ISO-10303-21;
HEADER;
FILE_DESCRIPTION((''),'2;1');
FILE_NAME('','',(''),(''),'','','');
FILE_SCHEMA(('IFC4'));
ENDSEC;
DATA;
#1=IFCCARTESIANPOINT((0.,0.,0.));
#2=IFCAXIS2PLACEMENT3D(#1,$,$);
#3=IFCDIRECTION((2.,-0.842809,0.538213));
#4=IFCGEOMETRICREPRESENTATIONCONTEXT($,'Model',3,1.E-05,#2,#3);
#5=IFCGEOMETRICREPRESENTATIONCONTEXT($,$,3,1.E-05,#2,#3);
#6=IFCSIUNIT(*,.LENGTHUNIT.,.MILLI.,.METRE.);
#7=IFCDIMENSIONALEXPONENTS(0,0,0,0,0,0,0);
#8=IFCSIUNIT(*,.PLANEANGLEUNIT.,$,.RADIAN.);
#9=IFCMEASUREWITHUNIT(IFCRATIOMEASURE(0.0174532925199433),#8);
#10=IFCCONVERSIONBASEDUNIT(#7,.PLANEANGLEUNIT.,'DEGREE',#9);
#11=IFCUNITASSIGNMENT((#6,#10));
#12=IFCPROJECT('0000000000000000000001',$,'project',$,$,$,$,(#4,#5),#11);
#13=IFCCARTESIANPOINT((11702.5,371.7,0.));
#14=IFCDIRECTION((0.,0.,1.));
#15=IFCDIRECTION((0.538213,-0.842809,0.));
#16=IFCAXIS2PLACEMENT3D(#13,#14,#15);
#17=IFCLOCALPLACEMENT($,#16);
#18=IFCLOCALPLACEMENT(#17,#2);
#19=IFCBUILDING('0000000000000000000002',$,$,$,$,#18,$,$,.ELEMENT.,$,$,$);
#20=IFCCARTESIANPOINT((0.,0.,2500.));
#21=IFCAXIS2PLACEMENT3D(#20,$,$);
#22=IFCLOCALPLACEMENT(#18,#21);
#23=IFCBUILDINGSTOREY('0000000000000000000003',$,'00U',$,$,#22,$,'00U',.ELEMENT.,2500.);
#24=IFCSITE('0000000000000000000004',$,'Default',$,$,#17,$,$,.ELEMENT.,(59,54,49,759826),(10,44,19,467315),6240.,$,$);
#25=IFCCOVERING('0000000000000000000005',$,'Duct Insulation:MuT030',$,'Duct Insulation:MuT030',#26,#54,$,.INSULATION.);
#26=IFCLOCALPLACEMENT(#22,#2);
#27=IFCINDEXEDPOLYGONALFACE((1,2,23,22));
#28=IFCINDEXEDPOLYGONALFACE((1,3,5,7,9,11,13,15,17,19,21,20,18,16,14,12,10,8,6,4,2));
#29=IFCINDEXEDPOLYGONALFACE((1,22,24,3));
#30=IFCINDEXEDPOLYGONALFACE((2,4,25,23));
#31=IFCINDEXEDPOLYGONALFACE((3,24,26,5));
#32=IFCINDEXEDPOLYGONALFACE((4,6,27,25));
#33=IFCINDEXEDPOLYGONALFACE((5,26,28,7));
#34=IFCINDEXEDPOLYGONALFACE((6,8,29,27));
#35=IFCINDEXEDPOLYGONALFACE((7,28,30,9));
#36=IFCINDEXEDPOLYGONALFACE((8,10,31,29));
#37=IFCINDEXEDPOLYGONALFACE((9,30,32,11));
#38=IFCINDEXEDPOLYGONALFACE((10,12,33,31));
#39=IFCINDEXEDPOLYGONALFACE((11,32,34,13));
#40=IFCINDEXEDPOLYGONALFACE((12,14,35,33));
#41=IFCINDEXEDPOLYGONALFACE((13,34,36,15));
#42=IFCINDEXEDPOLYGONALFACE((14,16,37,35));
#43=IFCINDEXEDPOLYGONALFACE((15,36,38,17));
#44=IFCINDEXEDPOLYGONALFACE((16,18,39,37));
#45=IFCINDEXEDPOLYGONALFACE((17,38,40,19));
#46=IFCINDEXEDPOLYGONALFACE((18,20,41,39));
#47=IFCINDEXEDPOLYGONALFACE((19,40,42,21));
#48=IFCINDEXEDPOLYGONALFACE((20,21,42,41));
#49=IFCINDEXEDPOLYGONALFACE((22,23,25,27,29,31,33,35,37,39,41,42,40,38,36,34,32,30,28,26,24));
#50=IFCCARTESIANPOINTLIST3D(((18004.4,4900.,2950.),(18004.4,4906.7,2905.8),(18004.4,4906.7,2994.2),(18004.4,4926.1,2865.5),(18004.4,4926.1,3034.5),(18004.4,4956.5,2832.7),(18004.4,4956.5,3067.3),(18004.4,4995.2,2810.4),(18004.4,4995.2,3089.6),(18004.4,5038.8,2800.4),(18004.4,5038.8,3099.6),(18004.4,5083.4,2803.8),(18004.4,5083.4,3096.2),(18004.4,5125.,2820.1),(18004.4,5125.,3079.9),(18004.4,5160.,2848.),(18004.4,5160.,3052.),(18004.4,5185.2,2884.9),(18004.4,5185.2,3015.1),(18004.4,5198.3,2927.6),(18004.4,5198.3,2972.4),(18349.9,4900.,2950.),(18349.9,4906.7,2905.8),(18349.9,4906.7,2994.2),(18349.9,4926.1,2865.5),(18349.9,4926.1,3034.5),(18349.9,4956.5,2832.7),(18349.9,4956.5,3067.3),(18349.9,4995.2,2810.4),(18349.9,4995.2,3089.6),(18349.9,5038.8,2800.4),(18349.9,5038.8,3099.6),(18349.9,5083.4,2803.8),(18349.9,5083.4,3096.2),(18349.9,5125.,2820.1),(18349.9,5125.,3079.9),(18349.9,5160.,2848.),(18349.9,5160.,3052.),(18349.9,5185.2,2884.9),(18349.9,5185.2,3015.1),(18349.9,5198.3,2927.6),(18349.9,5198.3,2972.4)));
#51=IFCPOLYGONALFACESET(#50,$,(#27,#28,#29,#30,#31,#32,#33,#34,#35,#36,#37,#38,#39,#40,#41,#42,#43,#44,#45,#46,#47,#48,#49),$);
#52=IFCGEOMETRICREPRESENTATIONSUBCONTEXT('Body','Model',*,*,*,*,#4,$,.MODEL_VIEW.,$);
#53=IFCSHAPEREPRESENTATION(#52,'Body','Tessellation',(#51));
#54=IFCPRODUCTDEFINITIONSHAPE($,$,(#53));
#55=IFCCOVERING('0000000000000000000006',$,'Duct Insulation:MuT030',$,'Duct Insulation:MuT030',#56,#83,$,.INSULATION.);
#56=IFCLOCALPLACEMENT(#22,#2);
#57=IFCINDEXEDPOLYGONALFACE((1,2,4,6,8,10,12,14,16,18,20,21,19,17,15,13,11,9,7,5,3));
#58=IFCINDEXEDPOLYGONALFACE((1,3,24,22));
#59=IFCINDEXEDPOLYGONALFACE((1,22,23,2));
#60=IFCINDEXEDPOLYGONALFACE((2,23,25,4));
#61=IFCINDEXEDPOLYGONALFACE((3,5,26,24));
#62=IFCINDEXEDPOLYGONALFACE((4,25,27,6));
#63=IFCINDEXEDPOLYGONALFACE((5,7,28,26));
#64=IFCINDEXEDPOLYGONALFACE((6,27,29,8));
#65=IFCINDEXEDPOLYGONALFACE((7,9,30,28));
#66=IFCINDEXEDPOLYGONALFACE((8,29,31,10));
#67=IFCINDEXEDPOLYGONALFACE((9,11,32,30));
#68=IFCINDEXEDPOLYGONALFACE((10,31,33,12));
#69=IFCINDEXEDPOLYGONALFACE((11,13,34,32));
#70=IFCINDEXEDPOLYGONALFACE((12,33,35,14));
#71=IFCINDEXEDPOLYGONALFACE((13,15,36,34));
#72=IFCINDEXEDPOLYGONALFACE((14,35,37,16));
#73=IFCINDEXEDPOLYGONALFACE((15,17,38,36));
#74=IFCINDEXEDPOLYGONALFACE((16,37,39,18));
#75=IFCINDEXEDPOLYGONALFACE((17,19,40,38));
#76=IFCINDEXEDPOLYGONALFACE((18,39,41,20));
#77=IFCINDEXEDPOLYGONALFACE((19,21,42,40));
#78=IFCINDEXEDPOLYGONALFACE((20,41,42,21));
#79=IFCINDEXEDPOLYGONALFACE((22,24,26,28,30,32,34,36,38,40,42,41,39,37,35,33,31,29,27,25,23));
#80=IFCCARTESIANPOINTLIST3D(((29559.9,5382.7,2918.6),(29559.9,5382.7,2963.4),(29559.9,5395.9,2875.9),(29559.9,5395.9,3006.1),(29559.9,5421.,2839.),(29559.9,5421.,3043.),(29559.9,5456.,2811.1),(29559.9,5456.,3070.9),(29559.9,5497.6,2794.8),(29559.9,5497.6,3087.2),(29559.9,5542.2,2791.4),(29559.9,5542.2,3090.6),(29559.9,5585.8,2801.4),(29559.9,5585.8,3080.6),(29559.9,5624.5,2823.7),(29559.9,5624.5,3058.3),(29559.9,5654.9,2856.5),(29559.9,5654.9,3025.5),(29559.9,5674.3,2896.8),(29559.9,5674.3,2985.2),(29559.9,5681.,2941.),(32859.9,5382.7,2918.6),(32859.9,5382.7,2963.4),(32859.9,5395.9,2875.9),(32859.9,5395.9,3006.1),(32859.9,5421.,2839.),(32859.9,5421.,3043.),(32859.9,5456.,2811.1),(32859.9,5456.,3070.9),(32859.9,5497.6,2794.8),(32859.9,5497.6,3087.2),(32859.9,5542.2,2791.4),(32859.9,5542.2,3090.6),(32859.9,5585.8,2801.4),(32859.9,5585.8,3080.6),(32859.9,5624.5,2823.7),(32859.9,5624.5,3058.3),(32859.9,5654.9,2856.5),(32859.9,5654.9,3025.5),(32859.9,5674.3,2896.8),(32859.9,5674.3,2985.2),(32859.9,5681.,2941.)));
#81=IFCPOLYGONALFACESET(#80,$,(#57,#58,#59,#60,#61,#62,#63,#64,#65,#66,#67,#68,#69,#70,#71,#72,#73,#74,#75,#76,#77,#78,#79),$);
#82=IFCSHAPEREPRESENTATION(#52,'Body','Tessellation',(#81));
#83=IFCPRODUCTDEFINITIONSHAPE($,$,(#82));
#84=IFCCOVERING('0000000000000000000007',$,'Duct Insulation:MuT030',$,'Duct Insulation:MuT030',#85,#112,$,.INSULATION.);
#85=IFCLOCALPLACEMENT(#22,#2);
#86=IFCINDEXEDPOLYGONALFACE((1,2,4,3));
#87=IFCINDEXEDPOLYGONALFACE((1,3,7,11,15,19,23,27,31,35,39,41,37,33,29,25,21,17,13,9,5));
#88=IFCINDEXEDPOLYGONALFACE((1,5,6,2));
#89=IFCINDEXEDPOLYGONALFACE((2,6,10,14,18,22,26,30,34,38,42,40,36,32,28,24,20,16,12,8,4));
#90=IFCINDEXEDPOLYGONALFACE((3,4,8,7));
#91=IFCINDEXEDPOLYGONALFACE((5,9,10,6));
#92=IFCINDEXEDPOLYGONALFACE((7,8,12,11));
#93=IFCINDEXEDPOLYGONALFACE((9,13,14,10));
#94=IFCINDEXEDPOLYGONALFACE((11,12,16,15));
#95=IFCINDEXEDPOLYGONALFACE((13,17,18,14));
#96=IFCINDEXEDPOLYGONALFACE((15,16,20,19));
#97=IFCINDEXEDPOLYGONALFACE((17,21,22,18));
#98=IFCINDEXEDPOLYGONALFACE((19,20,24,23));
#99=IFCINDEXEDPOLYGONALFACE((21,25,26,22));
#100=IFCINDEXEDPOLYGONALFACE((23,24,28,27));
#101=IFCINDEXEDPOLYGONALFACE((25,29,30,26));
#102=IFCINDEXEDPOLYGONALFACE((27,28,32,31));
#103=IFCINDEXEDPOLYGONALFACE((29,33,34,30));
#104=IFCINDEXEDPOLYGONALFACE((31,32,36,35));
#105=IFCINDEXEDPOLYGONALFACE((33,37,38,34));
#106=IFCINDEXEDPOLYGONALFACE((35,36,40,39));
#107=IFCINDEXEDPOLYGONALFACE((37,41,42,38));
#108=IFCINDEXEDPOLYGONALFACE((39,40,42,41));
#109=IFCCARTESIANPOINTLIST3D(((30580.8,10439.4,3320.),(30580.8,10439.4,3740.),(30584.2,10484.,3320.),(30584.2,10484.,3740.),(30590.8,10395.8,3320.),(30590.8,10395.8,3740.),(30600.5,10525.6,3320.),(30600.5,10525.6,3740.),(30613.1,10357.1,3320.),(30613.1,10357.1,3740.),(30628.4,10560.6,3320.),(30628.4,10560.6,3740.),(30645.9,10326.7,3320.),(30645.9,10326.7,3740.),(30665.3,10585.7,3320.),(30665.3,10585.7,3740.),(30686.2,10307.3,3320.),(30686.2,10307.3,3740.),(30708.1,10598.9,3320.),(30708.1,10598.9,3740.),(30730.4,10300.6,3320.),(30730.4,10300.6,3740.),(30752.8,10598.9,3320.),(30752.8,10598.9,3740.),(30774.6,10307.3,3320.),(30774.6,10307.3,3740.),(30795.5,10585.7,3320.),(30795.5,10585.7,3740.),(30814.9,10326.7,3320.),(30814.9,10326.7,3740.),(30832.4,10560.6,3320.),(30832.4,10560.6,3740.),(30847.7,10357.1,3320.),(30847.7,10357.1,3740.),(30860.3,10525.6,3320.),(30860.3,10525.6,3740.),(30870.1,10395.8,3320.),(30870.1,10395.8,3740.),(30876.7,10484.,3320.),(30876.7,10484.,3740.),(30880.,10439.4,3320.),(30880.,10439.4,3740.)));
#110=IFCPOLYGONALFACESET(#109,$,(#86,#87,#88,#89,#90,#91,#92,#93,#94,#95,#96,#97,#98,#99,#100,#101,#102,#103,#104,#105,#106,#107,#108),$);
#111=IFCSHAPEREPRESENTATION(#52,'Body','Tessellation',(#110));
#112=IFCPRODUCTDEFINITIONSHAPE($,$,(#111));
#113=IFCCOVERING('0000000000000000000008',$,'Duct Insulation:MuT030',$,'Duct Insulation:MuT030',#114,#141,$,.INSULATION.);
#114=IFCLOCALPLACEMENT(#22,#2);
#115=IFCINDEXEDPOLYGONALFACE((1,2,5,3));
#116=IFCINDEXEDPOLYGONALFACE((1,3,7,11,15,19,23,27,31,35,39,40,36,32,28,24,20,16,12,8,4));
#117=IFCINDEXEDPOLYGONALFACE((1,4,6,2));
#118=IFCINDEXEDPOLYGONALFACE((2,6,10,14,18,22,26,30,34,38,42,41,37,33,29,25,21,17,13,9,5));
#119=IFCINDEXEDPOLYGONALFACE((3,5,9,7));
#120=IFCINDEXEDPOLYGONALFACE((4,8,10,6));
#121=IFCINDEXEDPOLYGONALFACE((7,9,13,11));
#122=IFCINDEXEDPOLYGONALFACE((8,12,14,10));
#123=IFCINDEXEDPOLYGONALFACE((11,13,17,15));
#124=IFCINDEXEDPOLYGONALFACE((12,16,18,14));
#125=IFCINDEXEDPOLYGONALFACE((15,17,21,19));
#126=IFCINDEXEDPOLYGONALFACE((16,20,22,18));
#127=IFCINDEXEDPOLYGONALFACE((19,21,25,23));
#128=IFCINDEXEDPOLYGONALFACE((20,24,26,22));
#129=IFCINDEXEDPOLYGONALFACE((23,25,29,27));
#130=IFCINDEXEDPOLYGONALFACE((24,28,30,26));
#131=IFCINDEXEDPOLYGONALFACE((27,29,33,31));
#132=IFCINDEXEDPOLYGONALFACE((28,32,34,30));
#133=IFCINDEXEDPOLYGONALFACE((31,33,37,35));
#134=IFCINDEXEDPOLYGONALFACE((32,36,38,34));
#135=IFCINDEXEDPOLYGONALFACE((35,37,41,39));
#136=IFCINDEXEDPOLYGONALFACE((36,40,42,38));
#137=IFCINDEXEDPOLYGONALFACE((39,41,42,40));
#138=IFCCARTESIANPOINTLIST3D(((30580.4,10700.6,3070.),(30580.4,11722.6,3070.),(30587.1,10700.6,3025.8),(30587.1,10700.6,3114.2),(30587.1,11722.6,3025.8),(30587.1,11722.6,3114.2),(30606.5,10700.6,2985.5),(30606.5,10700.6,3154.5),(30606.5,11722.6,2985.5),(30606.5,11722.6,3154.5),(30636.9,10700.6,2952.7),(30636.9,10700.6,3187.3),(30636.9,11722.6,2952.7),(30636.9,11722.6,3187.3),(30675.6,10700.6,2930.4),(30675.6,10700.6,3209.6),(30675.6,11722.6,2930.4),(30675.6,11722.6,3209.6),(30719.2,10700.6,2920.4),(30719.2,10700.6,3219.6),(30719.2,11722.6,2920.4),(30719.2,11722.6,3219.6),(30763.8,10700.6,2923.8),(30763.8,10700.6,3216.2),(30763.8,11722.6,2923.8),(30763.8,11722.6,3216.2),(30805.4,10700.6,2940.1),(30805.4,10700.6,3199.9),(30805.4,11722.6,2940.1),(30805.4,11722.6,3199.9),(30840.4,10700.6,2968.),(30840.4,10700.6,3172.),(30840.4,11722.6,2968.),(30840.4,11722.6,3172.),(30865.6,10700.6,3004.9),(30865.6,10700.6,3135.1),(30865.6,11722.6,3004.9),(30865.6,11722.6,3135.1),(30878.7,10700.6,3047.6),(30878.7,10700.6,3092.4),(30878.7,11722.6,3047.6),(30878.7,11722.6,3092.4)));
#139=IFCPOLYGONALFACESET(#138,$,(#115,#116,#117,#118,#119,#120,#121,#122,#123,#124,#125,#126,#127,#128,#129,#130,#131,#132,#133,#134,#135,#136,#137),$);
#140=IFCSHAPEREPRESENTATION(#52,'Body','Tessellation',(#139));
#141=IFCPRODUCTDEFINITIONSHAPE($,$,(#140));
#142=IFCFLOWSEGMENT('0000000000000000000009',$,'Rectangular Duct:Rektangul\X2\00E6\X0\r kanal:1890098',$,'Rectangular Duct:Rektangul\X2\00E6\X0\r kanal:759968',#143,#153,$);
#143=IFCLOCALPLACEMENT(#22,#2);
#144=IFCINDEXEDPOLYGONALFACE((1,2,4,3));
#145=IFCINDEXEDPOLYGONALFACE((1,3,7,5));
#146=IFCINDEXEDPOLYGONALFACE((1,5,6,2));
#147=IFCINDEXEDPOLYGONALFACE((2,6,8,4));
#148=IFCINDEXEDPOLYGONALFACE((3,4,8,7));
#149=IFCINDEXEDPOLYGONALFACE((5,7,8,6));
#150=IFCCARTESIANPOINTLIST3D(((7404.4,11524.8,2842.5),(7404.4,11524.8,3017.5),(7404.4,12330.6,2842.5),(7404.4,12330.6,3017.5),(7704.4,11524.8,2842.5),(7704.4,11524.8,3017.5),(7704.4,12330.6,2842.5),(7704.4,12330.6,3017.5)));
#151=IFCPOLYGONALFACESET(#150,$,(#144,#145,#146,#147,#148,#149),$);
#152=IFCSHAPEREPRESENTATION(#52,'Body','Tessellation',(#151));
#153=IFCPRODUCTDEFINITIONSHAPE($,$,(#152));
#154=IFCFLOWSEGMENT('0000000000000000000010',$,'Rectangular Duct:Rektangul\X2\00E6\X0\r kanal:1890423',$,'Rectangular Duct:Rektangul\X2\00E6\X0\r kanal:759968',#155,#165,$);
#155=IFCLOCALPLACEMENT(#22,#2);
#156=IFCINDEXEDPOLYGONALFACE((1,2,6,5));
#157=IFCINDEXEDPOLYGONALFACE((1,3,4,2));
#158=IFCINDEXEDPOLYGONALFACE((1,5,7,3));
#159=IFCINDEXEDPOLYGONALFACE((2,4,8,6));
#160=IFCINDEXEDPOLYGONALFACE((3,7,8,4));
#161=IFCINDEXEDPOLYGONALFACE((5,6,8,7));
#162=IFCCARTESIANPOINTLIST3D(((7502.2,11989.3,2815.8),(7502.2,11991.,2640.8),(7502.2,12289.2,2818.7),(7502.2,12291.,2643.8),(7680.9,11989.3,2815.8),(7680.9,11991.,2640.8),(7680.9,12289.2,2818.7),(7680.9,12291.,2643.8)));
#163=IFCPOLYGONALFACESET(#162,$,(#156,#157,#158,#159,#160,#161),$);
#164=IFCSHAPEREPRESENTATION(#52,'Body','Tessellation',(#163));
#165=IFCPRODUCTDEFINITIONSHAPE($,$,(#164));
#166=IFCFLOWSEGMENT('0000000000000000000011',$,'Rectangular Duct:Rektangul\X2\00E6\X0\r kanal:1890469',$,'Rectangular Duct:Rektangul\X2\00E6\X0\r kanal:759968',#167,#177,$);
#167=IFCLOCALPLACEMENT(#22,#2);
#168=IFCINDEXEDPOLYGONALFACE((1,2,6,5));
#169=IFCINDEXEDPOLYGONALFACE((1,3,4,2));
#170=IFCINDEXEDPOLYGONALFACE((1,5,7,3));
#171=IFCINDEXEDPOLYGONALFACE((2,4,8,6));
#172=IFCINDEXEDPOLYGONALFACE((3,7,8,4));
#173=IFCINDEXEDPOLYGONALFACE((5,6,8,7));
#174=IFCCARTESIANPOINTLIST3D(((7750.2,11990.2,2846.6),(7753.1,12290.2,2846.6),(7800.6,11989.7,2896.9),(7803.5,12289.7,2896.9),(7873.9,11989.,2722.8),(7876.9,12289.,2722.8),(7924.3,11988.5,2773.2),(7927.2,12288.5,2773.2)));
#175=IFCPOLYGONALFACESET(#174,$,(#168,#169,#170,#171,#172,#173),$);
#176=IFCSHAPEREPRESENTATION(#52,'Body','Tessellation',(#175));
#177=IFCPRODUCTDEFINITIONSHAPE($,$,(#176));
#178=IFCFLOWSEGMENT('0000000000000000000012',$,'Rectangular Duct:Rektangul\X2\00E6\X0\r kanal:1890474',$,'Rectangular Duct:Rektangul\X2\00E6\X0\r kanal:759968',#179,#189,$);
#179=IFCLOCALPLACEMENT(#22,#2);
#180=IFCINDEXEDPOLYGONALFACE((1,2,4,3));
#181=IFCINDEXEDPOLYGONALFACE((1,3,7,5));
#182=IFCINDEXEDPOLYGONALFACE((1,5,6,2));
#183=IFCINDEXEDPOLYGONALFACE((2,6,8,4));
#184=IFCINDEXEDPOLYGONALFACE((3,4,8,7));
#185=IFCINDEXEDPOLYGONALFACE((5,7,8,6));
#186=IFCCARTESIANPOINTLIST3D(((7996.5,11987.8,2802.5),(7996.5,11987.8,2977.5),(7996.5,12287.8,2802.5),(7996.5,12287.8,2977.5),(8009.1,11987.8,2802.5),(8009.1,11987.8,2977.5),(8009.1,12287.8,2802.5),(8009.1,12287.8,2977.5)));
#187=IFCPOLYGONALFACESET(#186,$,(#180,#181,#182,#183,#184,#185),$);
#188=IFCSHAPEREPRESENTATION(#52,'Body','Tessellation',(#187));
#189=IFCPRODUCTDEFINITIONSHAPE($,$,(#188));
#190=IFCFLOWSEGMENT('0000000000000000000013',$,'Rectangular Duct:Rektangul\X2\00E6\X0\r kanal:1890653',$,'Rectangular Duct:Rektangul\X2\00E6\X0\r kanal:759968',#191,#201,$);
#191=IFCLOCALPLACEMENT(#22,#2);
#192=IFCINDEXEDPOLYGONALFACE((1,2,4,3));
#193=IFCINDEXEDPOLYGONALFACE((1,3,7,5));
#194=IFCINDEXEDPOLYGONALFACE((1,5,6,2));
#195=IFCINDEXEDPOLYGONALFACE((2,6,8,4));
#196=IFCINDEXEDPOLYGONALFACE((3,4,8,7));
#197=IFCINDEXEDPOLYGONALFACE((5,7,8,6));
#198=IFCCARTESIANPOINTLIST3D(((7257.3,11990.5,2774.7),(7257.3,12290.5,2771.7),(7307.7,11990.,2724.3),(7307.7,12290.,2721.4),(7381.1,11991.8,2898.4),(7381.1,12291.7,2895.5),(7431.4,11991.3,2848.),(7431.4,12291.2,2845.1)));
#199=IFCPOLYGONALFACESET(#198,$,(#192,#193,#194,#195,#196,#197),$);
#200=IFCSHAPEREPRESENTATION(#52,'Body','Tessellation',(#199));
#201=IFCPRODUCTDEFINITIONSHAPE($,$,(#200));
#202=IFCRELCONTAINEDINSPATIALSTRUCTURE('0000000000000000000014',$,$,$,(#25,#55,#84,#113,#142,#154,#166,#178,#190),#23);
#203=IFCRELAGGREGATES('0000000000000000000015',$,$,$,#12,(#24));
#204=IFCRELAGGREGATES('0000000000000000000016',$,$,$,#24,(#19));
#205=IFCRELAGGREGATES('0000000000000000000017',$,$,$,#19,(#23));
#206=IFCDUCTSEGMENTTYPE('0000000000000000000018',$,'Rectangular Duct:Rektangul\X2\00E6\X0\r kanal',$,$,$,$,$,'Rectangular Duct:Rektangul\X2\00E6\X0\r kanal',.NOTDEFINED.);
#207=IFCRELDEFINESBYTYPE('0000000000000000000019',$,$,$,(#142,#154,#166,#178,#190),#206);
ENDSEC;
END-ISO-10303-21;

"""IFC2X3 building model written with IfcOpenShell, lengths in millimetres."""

from ifc_helpers import new_model, entity, si_unit, converted_unit, direction, frame, frame_2d, origin, origin_2d_with_axis, place, context, subcontext, project, spatial, rectangle, circle, extrude, type_object, element, save


model = new_model("IFC2X3")

# Units and contexts
model_context = context("Model", 3, precision=1e-05, world=origin(), true_north=direction((2.0, -0.842809, 0.538213)))
context_of_model = context(None, 3, precision=1e-05, world=origin(), true_north=direction((2.0, -0.842809, 0.538213)))
body_context = subcontext(model_context, "Body", "Model", "MODEL_VIEW")
ifc_project = project(units=[si_unit("LENGTHUNIT", "METRE", prefix="MILLI"), converted_unit("PLANEANGLEUNIT", "DEGREE", entity("IfcRatioMeasure", 0.0174532925199433), si_unit("PLANEANGLEUNIT", "RADIAN"), dimensions=[0, 0, 0, 0, 0, 0, 0])], contexts=[model_context, context_of_model])

# Site, building, storey
site_placement = place(None, frame((11702.5, 371.7, 0.0), z_axis=(0.0, 0.0, 1.0), x_axis=(0.538213, -0.842809, 0.0)))
site = spatial("IfcSite", under=ifc_project, at=site_placement, Name="Default", CompositionType="ELEMENT", RefLatitude=(59, 54, 49, 759826), RefLongitude=(10, 44, 19, 467315), RefElevation=6240.0)
building_placement = place(site_placement, origin())
building = spatial("IfcBuilding", under=site, at=building_placement, CompositionType="ELEMENT")
storey_placement = place(building_placement, frame((0.0, 0.0, 2500.0)))
storey = spatial("IfcBuildingStorey", under=building, at=storey_placement, Name="00U", LongName="00U", CompositionType="ELEMENT", Elevation=2500.0)

# Coverings
covering_1_placement = place(storey_placement, origin())
element("IfcCovering", 1, at=covering_1_placement, inside=storey, Name="Duct Insulation:MuT030", ObjectType="Duct Insulation:MuT030", PredefinedType="INSULATION", context=body_context, shape_type="SweptSolid", body=[
    extrude(circle(Radius=150.0, at=origin_2d_with_axis()), frame((18004.4, 5050.0, 2950.0), z_axis=(1.0, 0.0, 0.0), x_axis=(0.0, -1.0, 0.0)), (0.0, 0.0, 1.0), 345.4),
])
covering_2_placement = place(storey_placement, origin())
element("IfcCovering", 2, at=covering_2_placement, inside=storey, Name="Duct Insulation:MuT030", ObjectType="Duct Insulation:MuT030", PredefinedType="INSULATION", context=body_context, shape_type="SweptSolid", body=[
    extrude(circle(Radius=150.0, at=frame_2d((0.0, 0.0), x_axis=(1.0, 0.0))), frame((29559.9, 5531.0, 2941.0), z_axis=(1.0, 0.0, 0.0), x_axis=(0.0, 1.0, 0.0)), (0.0, 0.0, 1.0), 3300.0),
])
covering_3_placement = place(storey_placement, origin())
element("IfcCovering", 3, at=covering_3_placement, inside=storey, Name="Duct Insulation:MuT030", ObjectType="Duct Insulation:MuT030", PredefinedType="INSULATION", context=body_context, shape_type="SweptSolid", body=[
    extrude(circle(Radius=150.0, at=origin_2d_with_axis()), frame((30730.4, 10450.6, 3320.0), z_axis=(0.0, 0.0, 1.0), x_axis=(0.0, -1.0, 0.0)), (0.0, 0.0, 1.0), 420.0),
])
covering_4_placement = place(storey_placement, origin())
element("IfcCovering", 4, at=covering_4_placement, inside=storey, Name="Duct Insulation:MuT030", ObjectType="Duct Insulation:MuT030", PredefinedType="INSULATION", context=body_context, shape_type="SweptSolid", body=[
    extrude(circle(Radius=150.0, at=frame_2d((0.0, 0.0), x_axis=(1.0, 0.0))), frame((30730.4, 10700.6, 3070.0), z_axis=(0.0, 1.0, 0.0), x_axis=(-1.0, 0.0, 0.0)), (0.0, 0.0, 1.0), 1022.0),
])

# Flow segments
duct_segment_type_1 = type_object("IfcDuctSegmentType", Name="Rectangular Duct:Rektangulær kanal", ElementType="Rectangular Duct:Rektangulær kanal", PredefinedType="NOTDEFINED")
flow_segment_1_placement = place(storey_placement, origin())
element("IfcFlowSegment", 5, at=flow_segment_1_placement, inside=storey, type_object=duct_segment_type_1, Name="Rectangular Duct:Rektangulær kanal:1890098", ObjectType="Rectangular Duct:Rektangulær kanal:759968", context=body_context, shape_type="SweptSolid", body=[
    extrude(rectangle(XDim=805.8, YDim=300.0, at=frame_2d((0.0, 0.0), x_axis=(1.0, 0.0))), frame((7554.4, 11927.7, 2842.5), z_axis=(0.0, 0.0, 1.0), x_axis=(0.0, -1.0, 0.0)), (0.0, 0.0, 1.0), 175.0),
])
flow_segment_2_placement = place(storey_placement, origin())
element("IfcFlowSegment", 6, at=flow_segment_2_placement, inside=storey, type_object=duct_segment_type_1, Name="Rectangular Duct:Rektangulær kanal:1890423", ObjectType="Rectangular Duct:Rektangulær kanal:759968", context=body_context, shape_type="SweptSolid", body=[
    extrude(rectangle(XDim=175.0, YDim=300.0, at=frame_2d((0.0, 0.0), x_axis=(1.0, 0.0))), frame((7502.2, 12140.1, 2729.8), z_axis=(1.0, 0.0, 0.0), x_axis=(0.0, 0.00981, -0.999952)), (0.0, 0.0, 1.0), 178.8),
])
flow_segment_3_placement = place(storey_placement, origin())
element("IfcFlowSegment", 7, at=flow_segment_3_placement, inside=storey, type_object=duct_segment_type_1, Name="Rectangular Duct:Rektangulær kanal:1890469", ObjectType="Rectangular Duct:Rektangulær kanal:759968", context=body_context, shape_type="SweptSolid", body=[
    extrude(rectangle(XDim=175.0, YDim=71.2, at=frame_2d((0.0, 0.0), x_axis=(0.0, 1.0))), frame((7837.2, 11989.3, 2809.9), z_axis=(0.00981, 0.999952, 0.0), x_axis=(0.707073, -0.006937, 0.707107)), (0.0, 0.0, 1.0), 300.0),
])
flow_segment_4_placement = place(storey_placement, origin())
element("IfcFlowSegment", 8, at=flow_segment_4_placement, inside=storey, type_object=duct_segment_type_1, Name="Rectangular Duct:Rektangulær kanal:1890474", ObjectType="Rectangular Duct:Rektangulær kanal:759968", context=body_context, shape_type="SweptSolid", body=[
    extrude(rectangle(XDim=12.6, YDim=300.0, at=frame_2d((0.0, 0.0), x_axis=(1.0, 0.0))), frame((8002.8, 12137.8, 2802.5)), (0.0, 0.0, 1.0), 175.0),
])
flow_segment_5_placement = place(storey_placement, origin())
element("IfcFlowSegment", 9, at=flow_segment_5_placement, inside=storey, type_object=duct_segment_type_1, Name="Rectangular Duct:Rektangulær kanal:1890653", ObjectType="Rectangular Duct:Rektangulær kanal:759968", context=body_context, shape_type="SweptSolid", body=[
    extrude(rectangle(XDim=71.3, YDim=175.0, at=frame_2d((0.0, 0.0), x_axis=(1.0, 0.0))), frame((7344.4, 11990.9, 2811.4), z_axis=(0.0, 0.999952, -0.00981), x_axis=(-0.707073, 0.006937, 0.707107)), (0.0, 0.0, 1.0), 300.0),
])

save(model, "model.ifc")
